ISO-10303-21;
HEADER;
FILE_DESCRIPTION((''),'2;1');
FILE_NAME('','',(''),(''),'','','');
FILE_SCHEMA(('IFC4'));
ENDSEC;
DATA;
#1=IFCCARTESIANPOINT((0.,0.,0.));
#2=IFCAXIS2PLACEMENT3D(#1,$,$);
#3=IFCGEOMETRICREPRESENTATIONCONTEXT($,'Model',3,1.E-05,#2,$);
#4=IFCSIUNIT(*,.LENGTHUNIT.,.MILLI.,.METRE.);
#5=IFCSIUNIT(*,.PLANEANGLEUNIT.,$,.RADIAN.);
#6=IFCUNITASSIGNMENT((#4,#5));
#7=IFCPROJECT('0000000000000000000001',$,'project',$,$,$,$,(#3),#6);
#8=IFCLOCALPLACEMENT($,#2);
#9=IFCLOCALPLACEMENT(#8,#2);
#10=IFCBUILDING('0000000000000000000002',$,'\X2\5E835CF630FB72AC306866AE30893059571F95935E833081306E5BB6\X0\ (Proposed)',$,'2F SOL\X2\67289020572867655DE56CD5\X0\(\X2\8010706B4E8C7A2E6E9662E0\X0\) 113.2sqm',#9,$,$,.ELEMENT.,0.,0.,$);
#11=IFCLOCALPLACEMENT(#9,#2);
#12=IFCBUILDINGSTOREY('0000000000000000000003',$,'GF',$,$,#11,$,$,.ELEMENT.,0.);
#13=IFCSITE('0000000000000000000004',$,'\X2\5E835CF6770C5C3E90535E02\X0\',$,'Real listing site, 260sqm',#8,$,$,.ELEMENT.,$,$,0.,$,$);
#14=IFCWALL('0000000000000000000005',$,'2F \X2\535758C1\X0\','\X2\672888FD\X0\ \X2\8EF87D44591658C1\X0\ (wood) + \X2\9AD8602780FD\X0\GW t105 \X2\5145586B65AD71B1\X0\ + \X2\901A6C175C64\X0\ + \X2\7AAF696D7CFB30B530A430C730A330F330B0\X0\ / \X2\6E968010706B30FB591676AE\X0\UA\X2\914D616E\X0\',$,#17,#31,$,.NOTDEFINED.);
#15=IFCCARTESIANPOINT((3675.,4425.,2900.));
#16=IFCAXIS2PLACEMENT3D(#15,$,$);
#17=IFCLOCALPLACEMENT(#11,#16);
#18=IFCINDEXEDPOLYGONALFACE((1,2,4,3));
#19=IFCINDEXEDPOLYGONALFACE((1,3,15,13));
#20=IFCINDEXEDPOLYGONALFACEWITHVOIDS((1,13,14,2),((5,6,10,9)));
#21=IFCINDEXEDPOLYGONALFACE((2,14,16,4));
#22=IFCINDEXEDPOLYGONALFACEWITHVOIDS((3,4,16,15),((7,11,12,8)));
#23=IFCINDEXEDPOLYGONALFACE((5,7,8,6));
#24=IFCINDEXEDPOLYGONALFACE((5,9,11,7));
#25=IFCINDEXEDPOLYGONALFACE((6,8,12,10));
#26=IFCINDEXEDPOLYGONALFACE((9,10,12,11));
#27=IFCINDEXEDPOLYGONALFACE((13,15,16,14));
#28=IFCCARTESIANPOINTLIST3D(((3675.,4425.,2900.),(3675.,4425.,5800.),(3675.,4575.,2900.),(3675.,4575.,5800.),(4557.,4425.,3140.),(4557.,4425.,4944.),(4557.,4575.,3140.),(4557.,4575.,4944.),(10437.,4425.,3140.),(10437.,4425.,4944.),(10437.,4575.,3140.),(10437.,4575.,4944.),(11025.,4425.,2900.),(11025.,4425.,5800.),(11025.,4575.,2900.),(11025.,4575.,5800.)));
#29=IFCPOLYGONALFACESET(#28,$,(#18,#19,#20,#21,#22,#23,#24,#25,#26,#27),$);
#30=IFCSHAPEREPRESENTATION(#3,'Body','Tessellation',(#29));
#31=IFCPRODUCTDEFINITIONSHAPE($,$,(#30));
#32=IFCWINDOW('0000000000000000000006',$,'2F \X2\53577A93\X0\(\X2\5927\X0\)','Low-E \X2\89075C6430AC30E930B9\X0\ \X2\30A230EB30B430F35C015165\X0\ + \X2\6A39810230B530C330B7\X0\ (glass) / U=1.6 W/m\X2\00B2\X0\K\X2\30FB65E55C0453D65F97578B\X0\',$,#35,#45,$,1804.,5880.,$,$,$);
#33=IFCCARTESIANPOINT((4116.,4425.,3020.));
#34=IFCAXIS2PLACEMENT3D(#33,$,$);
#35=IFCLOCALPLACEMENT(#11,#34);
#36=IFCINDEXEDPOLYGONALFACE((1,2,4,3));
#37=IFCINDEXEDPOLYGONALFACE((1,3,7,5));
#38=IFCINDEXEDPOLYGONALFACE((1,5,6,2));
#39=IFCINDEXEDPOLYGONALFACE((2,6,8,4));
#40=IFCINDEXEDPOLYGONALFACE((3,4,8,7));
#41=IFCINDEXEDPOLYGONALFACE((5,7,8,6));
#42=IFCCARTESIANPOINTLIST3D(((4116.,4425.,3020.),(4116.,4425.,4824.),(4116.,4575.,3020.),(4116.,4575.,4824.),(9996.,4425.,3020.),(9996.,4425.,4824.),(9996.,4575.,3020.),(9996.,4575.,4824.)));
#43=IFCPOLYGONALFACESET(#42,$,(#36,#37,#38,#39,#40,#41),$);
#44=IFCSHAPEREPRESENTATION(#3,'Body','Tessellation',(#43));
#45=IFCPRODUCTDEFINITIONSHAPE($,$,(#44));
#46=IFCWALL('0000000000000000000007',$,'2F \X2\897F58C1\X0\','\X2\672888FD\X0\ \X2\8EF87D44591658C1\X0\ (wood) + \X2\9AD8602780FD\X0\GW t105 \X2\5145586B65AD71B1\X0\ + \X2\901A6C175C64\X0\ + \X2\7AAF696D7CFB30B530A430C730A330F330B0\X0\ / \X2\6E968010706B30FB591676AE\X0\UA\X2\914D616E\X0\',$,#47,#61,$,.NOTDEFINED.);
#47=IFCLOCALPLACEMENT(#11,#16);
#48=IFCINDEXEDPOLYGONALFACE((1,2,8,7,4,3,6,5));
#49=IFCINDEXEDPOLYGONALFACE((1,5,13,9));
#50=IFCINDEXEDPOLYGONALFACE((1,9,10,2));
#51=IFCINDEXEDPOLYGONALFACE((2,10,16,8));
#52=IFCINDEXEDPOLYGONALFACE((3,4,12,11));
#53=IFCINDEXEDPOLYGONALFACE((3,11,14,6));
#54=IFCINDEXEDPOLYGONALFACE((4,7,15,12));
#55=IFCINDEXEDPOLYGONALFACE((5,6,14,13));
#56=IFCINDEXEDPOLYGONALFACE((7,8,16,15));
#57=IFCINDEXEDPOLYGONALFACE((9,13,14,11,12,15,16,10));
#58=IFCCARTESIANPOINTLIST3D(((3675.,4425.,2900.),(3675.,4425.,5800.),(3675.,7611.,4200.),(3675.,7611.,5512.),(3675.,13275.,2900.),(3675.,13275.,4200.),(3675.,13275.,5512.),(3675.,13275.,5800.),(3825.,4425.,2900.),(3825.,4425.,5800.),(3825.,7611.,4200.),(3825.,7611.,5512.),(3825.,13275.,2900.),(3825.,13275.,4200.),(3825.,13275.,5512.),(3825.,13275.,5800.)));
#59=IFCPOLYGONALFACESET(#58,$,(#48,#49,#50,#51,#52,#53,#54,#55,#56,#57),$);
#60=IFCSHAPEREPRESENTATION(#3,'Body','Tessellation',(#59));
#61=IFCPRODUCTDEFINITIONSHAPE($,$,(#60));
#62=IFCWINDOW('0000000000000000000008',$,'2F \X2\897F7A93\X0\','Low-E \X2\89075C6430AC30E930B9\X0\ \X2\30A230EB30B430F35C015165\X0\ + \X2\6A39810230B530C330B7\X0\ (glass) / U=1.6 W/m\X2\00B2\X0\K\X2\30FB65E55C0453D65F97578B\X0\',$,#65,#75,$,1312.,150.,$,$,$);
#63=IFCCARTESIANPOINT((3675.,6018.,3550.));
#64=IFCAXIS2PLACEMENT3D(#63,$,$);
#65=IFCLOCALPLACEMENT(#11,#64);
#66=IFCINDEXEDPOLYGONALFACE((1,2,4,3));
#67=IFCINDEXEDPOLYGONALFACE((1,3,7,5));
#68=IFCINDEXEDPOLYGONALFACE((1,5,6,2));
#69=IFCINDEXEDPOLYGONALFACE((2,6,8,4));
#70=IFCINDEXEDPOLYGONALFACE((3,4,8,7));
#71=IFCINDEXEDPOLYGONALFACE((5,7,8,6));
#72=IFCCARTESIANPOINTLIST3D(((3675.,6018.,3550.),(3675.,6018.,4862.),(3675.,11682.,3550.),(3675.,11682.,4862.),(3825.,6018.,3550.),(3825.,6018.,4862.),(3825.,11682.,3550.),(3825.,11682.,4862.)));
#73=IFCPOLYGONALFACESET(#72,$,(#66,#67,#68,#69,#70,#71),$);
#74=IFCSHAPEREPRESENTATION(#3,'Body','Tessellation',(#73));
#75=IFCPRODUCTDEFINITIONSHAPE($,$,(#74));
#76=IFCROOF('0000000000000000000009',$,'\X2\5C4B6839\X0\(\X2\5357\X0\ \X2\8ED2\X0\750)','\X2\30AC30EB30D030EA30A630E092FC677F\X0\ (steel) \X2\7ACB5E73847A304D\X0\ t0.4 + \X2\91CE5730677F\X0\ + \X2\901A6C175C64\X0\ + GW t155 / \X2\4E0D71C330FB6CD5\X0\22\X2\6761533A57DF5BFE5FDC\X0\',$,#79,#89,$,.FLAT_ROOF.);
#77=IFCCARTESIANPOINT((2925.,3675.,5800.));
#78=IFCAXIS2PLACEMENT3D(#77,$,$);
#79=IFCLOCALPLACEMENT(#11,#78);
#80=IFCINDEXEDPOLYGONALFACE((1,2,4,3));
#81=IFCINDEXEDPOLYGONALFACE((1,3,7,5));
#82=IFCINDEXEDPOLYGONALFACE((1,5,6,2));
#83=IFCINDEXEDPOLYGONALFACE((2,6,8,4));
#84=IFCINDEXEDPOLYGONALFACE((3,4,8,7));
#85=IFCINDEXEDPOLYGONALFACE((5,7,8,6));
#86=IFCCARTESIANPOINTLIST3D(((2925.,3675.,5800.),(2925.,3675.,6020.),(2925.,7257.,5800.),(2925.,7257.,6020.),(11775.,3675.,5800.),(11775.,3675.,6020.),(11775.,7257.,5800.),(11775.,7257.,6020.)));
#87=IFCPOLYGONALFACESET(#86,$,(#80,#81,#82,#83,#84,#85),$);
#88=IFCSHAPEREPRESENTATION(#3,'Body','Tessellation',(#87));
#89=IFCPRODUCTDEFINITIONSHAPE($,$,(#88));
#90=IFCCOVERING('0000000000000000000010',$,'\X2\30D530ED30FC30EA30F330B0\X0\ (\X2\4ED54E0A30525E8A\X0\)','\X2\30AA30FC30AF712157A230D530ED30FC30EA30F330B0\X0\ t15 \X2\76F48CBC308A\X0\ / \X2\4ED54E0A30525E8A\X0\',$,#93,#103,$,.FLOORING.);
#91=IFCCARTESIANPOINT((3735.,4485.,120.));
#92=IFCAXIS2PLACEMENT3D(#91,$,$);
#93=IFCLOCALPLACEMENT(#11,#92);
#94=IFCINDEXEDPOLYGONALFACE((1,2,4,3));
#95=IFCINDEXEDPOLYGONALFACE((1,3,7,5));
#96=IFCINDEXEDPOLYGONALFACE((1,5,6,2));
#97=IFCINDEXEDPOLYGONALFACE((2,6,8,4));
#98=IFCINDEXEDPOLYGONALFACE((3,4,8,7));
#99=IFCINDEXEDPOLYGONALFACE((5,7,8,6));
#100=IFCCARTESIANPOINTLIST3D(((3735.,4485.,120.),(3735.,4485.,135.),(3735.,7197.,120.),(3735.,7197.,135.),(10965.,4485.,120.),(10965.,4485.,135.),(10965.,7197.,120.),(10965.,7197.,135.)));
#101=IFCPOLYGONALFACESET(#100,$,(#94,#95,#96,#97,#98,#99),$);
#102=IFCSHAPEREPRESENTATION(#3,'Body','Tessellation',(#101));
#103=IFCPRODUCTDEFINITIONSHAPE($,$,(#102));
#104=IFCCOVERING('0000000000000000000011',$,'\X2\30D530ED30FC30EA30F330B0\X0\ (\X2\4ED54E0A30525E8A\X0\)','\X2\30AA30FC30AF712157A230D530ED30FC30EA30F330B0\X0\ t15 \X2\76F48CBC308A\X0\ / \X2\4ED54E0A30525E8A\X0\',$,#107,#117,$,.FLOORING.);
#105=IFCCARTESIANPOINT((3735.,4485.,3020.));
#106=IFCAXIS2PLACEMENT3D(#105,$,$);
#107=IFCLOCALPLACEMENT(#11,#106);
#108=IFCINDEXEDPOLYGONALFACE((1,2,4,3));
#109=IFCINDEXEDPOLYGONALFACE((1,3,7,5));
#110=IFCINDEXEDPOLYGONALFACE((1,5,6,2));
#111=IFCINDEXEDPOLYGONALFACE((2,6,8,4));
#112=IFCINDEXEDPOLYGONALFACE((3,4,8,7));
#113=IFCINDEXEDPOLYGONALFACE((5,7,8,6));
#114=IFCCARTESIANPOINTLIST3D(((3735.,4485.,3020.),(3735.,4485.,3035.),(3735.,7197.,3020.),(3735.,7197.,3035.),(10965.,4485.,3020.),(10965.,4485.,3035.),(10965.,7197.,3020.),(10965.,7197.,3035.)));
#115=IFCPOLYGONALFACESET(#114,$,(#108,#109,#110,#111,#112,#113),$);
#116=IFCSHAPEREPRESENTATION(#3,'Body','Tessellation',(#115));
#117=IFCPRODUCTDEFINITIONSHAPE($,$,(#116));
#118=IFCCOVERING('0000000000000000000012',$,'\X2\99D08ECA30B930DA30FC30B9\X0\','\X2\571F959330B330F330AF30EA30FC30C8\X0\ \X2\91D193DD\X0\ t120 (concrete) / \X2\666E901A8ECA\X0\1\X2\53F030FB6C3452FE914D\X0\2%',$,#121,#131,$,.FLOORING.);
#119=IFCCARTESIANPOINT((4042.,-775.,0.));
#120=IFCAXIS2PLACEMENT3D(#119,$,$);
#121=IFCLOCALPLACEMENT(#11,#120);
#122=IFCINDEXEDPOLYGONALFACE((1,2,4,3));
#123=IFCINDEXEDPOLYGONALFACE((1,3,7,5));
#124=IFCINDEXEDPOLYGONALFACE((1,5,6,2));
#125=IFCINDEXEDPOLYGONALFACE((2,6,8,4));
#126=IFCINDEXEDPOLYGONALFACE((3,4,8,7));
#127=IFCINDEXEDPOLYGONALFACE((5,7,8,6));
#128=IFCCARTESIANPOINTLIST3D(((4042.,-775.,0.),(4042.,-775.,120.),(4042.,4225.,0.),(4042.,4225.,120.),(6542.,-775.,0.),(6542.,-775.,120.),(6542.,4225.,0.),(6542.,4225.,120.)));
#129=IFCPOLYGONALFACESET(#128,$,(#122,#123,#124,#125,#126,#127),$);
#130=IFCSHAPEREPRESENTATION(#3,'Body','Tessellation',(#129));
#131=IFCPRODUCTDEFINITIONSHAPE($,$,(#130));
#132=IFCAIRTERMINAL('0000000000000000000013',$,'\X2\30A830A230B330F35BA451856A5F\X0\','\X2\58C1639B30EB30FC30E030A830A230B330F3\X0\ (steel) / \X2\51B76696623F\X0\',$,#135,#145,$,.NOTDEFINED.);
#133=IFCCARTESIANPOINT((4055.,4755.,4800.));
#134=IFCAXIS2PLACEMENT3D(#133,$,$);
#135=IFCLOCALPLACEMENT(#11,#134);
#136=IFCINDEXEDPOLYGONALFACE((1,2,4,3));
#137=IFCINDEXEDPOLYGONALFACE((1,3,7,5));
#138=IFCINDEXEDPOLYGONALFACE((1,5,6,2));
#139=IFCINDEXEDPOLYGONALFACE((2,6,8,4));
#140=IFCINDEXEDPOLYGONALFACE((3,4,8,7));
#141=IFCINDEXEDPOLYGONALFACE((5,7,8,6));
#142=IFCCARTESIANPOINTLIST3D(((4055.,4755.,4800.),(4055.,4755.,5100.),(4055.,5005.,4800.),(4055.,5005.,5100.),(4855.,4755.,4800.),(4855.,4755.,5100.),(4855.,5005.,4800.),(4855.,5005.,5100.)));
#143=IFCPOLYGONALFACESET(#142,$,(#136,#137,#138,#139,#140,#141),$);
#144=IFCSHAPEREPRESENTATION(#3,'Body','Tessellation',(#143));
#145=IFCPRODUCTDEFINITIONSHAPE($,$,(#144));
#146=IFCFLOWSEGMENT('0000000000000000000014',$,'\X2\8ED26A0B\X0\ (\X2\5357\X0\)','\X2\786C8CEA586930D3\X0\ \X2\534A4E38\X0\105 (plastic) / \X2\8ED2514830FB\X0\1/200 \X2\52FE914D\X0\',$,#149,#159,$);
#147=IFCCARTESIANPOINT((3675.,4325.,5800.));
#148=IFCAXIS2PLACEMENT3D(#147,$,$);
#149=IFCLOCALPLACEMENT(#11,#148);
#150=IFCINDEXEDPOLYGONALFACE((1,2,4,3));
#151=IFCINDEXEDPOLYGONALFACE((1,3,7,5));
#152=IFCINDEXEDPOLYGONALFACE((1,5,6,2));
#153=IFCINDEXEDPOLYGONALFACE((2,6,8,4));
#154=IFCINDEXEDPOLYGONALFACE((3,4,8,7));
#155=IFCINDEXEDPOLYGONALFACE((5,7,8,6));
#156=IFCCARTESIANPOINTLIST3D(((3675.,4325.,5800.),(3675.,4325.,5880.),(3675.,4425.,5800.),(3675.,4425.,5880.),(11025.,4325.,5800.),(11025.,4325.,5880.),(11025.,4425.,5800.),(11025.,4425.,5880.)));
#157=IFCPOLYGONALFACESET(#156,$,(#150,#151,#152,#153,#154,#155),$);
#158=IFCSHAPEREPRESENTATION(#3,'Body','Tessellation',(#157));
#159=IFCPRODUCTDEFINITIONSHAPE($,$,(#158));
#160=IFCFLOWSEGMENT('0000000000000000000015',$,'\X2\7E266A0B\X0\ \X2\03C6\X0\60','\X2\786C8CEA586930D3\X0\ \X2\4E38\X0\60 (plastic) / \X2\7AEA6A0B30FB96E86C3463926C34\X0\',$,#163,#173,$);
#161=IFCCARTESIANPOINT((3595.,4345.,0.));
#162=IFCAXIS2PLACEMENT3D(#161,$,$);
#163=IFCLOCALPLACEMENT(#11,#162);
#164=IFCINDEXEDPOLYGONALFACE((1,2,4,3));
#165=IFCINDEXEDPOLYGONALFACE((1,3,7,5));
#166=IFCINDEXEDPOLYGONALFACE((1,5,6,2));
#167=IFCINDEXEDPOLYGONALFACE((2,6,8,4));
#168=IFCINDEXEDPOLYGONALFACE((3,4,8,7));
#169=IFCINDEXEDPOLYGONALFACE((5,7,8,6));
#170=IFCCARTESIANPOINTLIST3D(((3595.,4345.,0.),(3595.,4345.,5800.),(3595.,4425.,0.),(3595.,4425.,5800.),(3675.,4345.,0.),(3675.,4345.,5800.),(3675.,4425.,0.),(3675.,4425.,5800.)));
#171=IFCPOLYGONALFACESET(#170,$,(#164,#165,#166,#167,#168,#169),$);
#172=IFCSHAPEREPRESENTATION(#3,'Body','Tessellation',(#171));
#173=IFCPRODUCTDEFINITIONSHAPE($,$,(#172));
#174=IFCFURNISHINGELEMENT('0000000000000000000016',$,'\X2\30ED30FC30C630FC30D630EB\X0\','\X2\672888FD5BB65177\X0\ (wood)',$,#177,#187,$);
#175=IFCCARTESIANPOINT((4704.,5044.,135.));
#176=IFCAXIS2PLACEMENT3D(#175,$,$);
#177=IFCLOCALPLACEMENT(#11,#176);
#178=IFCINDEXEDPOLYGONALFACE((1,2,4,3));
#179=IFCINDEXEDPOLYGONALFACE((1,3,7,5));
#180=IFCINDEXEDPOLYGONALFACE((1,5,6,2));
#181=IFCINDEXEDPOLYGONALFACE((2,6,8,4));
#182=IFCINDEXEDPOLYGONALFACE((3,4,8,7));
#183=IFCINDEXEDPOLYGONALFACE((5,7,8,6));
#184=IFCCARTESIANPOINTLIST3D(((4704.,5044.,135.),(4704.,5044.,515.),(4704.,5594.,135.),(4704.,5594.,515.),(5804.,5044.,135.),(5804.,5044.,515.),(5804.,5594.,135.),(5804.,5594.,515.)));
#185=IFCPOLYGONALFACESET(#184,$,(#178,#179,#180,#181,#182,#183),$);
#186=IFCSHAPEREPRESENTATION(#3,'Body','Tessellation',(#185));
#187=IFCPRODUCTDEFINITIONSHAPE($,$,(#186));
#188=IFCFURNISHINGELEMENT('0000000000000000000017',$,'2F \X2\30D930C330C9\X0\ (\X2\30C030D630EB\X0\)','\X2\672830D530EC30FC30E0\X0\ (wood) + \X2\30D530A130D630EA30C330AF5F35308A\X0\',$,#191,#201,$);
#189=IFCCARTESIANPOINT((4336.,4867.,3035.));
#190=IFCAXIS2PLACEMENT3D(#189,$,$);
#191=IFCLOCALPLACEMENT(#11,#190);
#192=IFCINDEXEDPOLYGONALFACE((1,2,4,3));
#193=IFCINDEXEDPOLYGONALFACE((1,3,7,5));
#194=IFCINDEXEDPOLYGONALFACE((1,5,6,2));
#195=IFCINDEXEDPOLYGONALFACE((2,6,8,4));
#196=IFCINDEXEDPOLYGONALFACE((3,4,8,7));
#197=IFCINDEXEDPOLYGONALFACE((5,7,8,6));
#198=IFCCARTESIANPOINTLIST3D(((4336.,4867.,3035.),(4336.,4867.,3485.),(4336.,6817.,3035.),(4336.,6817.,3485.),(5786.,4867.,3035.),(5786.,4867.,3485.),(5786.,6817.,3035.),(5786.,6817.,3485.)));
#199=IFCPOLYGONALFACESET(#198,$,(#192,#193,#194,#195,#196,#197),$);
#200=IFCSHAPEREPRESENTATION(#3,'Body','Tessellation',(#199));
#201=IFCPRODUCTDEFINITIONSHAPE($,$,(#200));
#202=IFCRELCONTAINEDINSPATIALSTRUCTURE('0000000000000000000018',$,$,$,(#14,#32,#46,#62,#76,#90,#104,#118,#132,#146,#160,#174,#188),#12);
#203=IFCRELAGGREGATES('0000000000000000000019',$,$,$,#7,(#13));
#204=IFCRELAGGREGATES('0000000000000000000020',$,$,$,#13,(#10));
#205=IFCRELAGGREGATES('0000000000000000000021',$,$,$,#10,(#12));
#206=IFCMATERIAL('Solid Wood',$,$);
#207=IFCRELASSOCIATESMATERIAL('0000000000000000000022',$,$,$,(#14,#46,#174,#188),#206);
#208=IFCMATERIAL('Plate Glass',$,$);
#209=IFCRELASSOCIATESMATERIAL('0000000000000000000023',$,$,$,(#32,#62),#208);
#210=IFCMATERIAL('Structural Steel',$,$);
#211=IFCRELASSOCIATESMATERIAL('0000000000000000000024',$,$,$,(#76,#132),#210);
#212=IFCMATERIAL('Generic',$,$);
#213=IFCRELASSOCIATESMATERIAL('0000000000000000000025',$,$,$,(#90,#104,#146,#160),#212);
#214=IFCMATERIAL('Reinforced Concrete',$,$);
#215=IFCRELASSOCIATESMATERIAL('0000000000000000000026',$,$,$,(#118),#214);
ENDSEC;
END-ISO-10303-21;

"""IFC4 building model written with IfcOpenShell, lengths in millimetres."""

from ifc_helpers import new_model, si_unit, frame, frame_2d, origin, place, context, project, spatial, rectangle, extrude, material, element, fill, save


model = new_model("IFC4")

# Units and contexts
model_context = context("Model", 3, precision=1e-05, world=origin())
ifc_project = project(units=[si_unit("LENGTHUNIT", "METRE", prefix="MILLI"), si_unit("PLANEANGLEUNIT", "RADIAN")], contexts=[model_context])

# Site, building, storey
site_placement = place(None, origin())
site = spatial("IfcSite", under=ifc_project, at=site_placement, Name="広島県尾道市", ObjectType="Real listing site, 260sqm", CompositionType="ELEMENT", RefElevation=0.0)
building_placement = place(site_placement, origin())
building = spatial("IfcBuilding", under=site, at=building_placement, Name="広島・犬と暮らす土間広めの家 (Proposed)", ObjectType="2F SOL木造在来工法(耐火二種準拠) 113.2sqm", CompositionType="ELEMENT", ElevationOfRefHeight=0.0, ElevationOfTerrain=0.0)
storey_placement = place(building_placement, origin())
storey = spatial("IfcBuildingStorey", under=building, at=storey_placement, Name="GF", CompositionType="ELEMENT", Elevation=0.0)

# Shared definitions
ifc_material_1 = material(Name="Solid Wood")

# Shared definitions
ifc_material_2 = material(Name="Reinforced Concrete")

# Shared definitions
ifc_material_3 = material(Name="Plate Glass")

# Walls, openings, windows
wall_1_placement = place(storey_placement, frame((3675.0, 4425.0, 2900.0)))
wall_1 = element("IfcWall", 1, at=wall_1_placement, inside=storey, material=ifc_material_1, Name="2F 南壁", Description="木製 軸組外壁 (wood) + 高性能GW t105 充填断熱 + 通気層 + 窯業系サイディング / 準耐火・外皮UA配慮", PredefinedType="NOTDEFINED", context=model_context, shape_type="SweptSolid", body=[
    extrude(rectangle(XDim=7350.0, YDim=150.0, at=frame_2d((3675.0, 75.0))), frame((3675.0, 4425.0, 2900.0)), (0.0, 0.0, 1.0), 2900.0),
])
opening_1_placement = place(storey_placement, frame((4116.0, 4425.0, 3020.0)))
opening_1 = element("IfcOpeningElement", 2, at=opening_1_placement, cuts=wall_1, PredefinedType="NOTDEFINED", context=model_context, shape_type="SweptSolid", body=[
    extrude(rectangle(XDim=5880.0, YDim=150.0, at=frame_2d((2940.0, 75.0))), frame((4116.0, 4425.0, 3020.0)), (0.0, 0.0, 1.0), 1804.0),
])
window_1_placement = place(storey_placement, frame((4116.0, 4425.0, 3020.0)))
window_1 = element("IfcWindow", 3, at=window_1_placement, inside=storey, material=ifc_material_3, Name="2F 南窓(大)", Description="Low-E 複層ガラス アルゴン封入 + 樹脂サッシ (glass) / U=1.6 W/m²K・日射取得型", OverallHeight=1804.0, OverallWidth=5880.0, context=model_context, shape_type="SweptSolid", body=[
    extrude(rectangle(XDim=5880.0, YDim=150.0, at=frame_2d((2940.0, 75.0))), frame((4116.0, 4425.0, 3020.0)), (0.0, 0.0, 1.0), 1804.0),
])
fill(opening_1, window_1)
wall_2_placement = place(storey_placement, frame((3675.0, 4425.0, 2900.0)))
wall_2 = element("IfcWall", 4, at=wall_2_placement, inside=storey, material=ifc_material_1, Name="2F 西壁", Description="木製 軸組外壁 (wood) + 高性能GW t105 充填断熱 + 通気層 + 窯業系サイディング / 準耐火・外皮UA配慮", PredefinedType="NOTDEFINED", context=model_context, shape_type="SweptSolid", body=[
    extrude(rectangle(XDim=150.0, YDim=8850.0, at=frame_2d((75.0, 4425.0))), frame((3675.0, 4425.0, 2900.0)), (0.0, 0.0, 1.0), 2900.0),
])
opening_2_placement = place(storey_placement, frame((3675.0, 6018.0, 3550.0)))
opening_2 = element("IfcOpeningElement", 5, at=opening_2_placement, cuts=wall_2, PredefinedType="NOTDEFINED", context=model_context, shape_type="SweptSolid", body=[
    extrude(rectangle(XDim=150.0, YDim=5664.0, at=frame_2d((75.0, 2832.0))), frame((3675.0, 6018.0, 3550.0)), (0.0, 0.0, 1.0), 1312.0),
])
window_2_placement = place(storey_placement, frame((3675.0, 6018.0, 3550.0)))
window_2 = element("IfcWindow", 6, at=window_2_placement, inside=storey, material=ifc_material_3, Name="2F 西窓", Description="Low-E 複層ガラス アルゴン封入 + 樹脂サッシ (glass) / U=1.6 W/m²K・日射取得型", OverallHeight=1312.0, OverallWidth=150.0, context=model_context, shape_type="SweptSolid", body=[
    extrude(rectangle(XDim=150.0, YDim=5664.0, at=frame_2d((75.0, 2832.0))), frame((3675.0, 6018.0, 3550.0)), (0.0, 0.0, 1.0), 1312.0),
])
fill(opening_2, window_2)

# Roof
ifc_material_4 = material(Name="Structural Steel")
for number, where, name in (
    (7, (2925.0, 3675.0, 5800.0), "屋根(南 軒750)"),
):
    element("IfcRoof", number, at=place(storey_placement, frame(where)), inside=storey, material=ifc_material_4, Name=name, Description="ガルバリウム鋼板 (steel) 立平葺き t0.4 + 野地板 + 通気層 + GW t155 / 不燃・法22条区域対応", PredefinedType="FLAT_ROOF", context=model_context, shape_type="SweptSolid", body=[
        extrude(rectangle(XDim=8850.0, YDim=3582.0, at=frame_2d((4425.0, 1791.0))), frame((2925.0, 3675.0, 5800.0)), (0.0, 0.0, 1.0), 220.0),
    ])

# Coverings
ifc_material_5 = material(Name="Generic")
covering_1_placement = place(storey_placement, frame((3735.0, 4485.0, 120.0)))
element("IfcCovering", 8, at=covering_1_placement, inside=storey, material=ifc_material_5, Name="フローリング (仕上げ床)", Description="オーク無垢フローリング t15 直貼り / 仕上げ床", PredefinedType="FLOORING", context=model_context, shape_type="SweptSolid", body=[
    extrude(rectangle(XDim=7230.0, YDim=2712.0, at=frame_2d((3615.0, 1356.0))), frame((3735.0, 4485.0, 120.0)), (0.0, 0.0, 1.0), 15.0),
])
covering_2_placement = place(storey_placement, frame((3735.0, 4485.0, 3020.0)))
element("IfcCovering", 9, at=covering_2_placement, inside=storey, material=ifc_material_5, Name="フローリング (仕上げ床)", Description="オーク無垢フローリング t15 直貼り / 仕上げ床", PredefinedType="FLOORING", context=model_context, shape_type="SweptSolid", body=[
    extrude(rectangle(XDim=7230.0, YDim=2712.0, at=frame_2d((3615.0, 1356.0))), frame((3735.0, 4485.0, 3020.0)), (0.0, 0.0, 1.0), 15.0),
])
covering_3_placement = place(storey_placement, frame((4042.0, -775.0, 0.0)))
element("IfcCovering", 10, at=covering_3_placement, inside=storey, material=ifc_material_2, Name="駐車スペース", Description="土間コンクリート 金鏝 t120 (concrete) / 普通車1台・水勾配2%", PredefinedType="FLOORING", context=model_context, shape_type="SweptSolid", body=[
    extrude(rectangle(XDim=2500.0, YDim=5000.0, at=frame_2d((1250.0, 2500.0))), frame((4042.0, -775.0, 0.0)), (0.0, 0.0, 1.0), 120.0),
])

# Air terminal
air_terminal_placement = place(storey_placement, frame((4055.0, 4755.0, 4800.0)))
element("IfcAirTerminal", 11, at=air_terminal_placement, inside=storey, material=ifc_material_4, Name="エアコン室内機", Description="壁掛ルームエアコン (steel) / 冷暖房", PredefinedType="NOTDEFINED", context=model_context, shape_type="SweptSolid", body=[
    extrude(rectangle(XDim=800.0, YDim=250.0, at=frame_2d((400.0, 125.0))), frame((4055.0, 4755.0, 4800.0)), (0.0, 0.0, 1.0), 300.0),
])

# Flow segments
flow_segment_1_placement = place(storey_placement, frame((3675.0, 4325.0, 5800.0)))
element("IfcFlowSegment", 12, at=flow_segment_1_placement, inside=storey, material=ifc_material_5, Name="軒樋 (南)", Description="硬質塩ビ 半丸105 (plastic) / 軒先・1/200 勾配", context=model_context, shape_type="SweptSolid", body=[
    extrude(rectangle(XDim=7350.0, YDim=100.0, at=frame_2d((3675.0, 50.0))), frame((3675.0, 4325.0, 5800.0)), (0.0, 0.0, 1.0), 80.0),
])
flow_segment_2_placement = place(storey_placement, frame((3595.0, 4345.0, 0.0)))
element("IfcFlowSegment", 13, at=flow_segment_2_placement, inside=storey, material=ifc_material_5, Name="縦樋 φ60", Description="硬質塩ビ 丸60 (plastic) / 竪樋・雨水排水", context=model_context, shape_type="SweptSolid", body=[
    extrude(rectangle(XDim=80.0, YDim=80.0, at=frame_2d((40.0, 40.0))), frame((3595.0, 4345.0, 0.0)), (0.0, 0.0, 1.0), 5800.0),
])

# Furnishing elements
furnishing_1_placement = place(storey_placement, frame((4704.0, 5044.0, 135.0)))
element("IfcFurnishingElement", 14, at=furnishing_1_placement, inside=storey, material=ifc_material_1, Name="ローテーブル", Description="木製家具 (wood)", context=model_context, shape_type="SweptSolid", body=[
    extrude(rectangle(XDim=1100.0, YDim=550.0, at=frame_2d((550.0, 275.0))), frame((4704.0, 5044.0, 135.0)), (0.0, 0.0, 1.0), 380.0),
])
furnishing_2_placement = place(storey_placement, frame((4336.0, 4867.0, 3035.0)))
element("IfcFurnishingElement", 15, at=furnishing_2_placement, inside=storey, material=ifc_material_1, Name="2F ベッド (ダブル)", Description="木フレーム (wood) + ファブリック張り", context=model_context, shape_type="SweptSolid", body=[
    extrude(rectangle(XDim=1450.0, YDim=1950.0, at=frame_2d((725.0, 975.0))), frame((4336.0, 4867.0, 3035.0)), (0.0, 0.0, 1.0), 450.0),
])

save(model, "model.ifc")
